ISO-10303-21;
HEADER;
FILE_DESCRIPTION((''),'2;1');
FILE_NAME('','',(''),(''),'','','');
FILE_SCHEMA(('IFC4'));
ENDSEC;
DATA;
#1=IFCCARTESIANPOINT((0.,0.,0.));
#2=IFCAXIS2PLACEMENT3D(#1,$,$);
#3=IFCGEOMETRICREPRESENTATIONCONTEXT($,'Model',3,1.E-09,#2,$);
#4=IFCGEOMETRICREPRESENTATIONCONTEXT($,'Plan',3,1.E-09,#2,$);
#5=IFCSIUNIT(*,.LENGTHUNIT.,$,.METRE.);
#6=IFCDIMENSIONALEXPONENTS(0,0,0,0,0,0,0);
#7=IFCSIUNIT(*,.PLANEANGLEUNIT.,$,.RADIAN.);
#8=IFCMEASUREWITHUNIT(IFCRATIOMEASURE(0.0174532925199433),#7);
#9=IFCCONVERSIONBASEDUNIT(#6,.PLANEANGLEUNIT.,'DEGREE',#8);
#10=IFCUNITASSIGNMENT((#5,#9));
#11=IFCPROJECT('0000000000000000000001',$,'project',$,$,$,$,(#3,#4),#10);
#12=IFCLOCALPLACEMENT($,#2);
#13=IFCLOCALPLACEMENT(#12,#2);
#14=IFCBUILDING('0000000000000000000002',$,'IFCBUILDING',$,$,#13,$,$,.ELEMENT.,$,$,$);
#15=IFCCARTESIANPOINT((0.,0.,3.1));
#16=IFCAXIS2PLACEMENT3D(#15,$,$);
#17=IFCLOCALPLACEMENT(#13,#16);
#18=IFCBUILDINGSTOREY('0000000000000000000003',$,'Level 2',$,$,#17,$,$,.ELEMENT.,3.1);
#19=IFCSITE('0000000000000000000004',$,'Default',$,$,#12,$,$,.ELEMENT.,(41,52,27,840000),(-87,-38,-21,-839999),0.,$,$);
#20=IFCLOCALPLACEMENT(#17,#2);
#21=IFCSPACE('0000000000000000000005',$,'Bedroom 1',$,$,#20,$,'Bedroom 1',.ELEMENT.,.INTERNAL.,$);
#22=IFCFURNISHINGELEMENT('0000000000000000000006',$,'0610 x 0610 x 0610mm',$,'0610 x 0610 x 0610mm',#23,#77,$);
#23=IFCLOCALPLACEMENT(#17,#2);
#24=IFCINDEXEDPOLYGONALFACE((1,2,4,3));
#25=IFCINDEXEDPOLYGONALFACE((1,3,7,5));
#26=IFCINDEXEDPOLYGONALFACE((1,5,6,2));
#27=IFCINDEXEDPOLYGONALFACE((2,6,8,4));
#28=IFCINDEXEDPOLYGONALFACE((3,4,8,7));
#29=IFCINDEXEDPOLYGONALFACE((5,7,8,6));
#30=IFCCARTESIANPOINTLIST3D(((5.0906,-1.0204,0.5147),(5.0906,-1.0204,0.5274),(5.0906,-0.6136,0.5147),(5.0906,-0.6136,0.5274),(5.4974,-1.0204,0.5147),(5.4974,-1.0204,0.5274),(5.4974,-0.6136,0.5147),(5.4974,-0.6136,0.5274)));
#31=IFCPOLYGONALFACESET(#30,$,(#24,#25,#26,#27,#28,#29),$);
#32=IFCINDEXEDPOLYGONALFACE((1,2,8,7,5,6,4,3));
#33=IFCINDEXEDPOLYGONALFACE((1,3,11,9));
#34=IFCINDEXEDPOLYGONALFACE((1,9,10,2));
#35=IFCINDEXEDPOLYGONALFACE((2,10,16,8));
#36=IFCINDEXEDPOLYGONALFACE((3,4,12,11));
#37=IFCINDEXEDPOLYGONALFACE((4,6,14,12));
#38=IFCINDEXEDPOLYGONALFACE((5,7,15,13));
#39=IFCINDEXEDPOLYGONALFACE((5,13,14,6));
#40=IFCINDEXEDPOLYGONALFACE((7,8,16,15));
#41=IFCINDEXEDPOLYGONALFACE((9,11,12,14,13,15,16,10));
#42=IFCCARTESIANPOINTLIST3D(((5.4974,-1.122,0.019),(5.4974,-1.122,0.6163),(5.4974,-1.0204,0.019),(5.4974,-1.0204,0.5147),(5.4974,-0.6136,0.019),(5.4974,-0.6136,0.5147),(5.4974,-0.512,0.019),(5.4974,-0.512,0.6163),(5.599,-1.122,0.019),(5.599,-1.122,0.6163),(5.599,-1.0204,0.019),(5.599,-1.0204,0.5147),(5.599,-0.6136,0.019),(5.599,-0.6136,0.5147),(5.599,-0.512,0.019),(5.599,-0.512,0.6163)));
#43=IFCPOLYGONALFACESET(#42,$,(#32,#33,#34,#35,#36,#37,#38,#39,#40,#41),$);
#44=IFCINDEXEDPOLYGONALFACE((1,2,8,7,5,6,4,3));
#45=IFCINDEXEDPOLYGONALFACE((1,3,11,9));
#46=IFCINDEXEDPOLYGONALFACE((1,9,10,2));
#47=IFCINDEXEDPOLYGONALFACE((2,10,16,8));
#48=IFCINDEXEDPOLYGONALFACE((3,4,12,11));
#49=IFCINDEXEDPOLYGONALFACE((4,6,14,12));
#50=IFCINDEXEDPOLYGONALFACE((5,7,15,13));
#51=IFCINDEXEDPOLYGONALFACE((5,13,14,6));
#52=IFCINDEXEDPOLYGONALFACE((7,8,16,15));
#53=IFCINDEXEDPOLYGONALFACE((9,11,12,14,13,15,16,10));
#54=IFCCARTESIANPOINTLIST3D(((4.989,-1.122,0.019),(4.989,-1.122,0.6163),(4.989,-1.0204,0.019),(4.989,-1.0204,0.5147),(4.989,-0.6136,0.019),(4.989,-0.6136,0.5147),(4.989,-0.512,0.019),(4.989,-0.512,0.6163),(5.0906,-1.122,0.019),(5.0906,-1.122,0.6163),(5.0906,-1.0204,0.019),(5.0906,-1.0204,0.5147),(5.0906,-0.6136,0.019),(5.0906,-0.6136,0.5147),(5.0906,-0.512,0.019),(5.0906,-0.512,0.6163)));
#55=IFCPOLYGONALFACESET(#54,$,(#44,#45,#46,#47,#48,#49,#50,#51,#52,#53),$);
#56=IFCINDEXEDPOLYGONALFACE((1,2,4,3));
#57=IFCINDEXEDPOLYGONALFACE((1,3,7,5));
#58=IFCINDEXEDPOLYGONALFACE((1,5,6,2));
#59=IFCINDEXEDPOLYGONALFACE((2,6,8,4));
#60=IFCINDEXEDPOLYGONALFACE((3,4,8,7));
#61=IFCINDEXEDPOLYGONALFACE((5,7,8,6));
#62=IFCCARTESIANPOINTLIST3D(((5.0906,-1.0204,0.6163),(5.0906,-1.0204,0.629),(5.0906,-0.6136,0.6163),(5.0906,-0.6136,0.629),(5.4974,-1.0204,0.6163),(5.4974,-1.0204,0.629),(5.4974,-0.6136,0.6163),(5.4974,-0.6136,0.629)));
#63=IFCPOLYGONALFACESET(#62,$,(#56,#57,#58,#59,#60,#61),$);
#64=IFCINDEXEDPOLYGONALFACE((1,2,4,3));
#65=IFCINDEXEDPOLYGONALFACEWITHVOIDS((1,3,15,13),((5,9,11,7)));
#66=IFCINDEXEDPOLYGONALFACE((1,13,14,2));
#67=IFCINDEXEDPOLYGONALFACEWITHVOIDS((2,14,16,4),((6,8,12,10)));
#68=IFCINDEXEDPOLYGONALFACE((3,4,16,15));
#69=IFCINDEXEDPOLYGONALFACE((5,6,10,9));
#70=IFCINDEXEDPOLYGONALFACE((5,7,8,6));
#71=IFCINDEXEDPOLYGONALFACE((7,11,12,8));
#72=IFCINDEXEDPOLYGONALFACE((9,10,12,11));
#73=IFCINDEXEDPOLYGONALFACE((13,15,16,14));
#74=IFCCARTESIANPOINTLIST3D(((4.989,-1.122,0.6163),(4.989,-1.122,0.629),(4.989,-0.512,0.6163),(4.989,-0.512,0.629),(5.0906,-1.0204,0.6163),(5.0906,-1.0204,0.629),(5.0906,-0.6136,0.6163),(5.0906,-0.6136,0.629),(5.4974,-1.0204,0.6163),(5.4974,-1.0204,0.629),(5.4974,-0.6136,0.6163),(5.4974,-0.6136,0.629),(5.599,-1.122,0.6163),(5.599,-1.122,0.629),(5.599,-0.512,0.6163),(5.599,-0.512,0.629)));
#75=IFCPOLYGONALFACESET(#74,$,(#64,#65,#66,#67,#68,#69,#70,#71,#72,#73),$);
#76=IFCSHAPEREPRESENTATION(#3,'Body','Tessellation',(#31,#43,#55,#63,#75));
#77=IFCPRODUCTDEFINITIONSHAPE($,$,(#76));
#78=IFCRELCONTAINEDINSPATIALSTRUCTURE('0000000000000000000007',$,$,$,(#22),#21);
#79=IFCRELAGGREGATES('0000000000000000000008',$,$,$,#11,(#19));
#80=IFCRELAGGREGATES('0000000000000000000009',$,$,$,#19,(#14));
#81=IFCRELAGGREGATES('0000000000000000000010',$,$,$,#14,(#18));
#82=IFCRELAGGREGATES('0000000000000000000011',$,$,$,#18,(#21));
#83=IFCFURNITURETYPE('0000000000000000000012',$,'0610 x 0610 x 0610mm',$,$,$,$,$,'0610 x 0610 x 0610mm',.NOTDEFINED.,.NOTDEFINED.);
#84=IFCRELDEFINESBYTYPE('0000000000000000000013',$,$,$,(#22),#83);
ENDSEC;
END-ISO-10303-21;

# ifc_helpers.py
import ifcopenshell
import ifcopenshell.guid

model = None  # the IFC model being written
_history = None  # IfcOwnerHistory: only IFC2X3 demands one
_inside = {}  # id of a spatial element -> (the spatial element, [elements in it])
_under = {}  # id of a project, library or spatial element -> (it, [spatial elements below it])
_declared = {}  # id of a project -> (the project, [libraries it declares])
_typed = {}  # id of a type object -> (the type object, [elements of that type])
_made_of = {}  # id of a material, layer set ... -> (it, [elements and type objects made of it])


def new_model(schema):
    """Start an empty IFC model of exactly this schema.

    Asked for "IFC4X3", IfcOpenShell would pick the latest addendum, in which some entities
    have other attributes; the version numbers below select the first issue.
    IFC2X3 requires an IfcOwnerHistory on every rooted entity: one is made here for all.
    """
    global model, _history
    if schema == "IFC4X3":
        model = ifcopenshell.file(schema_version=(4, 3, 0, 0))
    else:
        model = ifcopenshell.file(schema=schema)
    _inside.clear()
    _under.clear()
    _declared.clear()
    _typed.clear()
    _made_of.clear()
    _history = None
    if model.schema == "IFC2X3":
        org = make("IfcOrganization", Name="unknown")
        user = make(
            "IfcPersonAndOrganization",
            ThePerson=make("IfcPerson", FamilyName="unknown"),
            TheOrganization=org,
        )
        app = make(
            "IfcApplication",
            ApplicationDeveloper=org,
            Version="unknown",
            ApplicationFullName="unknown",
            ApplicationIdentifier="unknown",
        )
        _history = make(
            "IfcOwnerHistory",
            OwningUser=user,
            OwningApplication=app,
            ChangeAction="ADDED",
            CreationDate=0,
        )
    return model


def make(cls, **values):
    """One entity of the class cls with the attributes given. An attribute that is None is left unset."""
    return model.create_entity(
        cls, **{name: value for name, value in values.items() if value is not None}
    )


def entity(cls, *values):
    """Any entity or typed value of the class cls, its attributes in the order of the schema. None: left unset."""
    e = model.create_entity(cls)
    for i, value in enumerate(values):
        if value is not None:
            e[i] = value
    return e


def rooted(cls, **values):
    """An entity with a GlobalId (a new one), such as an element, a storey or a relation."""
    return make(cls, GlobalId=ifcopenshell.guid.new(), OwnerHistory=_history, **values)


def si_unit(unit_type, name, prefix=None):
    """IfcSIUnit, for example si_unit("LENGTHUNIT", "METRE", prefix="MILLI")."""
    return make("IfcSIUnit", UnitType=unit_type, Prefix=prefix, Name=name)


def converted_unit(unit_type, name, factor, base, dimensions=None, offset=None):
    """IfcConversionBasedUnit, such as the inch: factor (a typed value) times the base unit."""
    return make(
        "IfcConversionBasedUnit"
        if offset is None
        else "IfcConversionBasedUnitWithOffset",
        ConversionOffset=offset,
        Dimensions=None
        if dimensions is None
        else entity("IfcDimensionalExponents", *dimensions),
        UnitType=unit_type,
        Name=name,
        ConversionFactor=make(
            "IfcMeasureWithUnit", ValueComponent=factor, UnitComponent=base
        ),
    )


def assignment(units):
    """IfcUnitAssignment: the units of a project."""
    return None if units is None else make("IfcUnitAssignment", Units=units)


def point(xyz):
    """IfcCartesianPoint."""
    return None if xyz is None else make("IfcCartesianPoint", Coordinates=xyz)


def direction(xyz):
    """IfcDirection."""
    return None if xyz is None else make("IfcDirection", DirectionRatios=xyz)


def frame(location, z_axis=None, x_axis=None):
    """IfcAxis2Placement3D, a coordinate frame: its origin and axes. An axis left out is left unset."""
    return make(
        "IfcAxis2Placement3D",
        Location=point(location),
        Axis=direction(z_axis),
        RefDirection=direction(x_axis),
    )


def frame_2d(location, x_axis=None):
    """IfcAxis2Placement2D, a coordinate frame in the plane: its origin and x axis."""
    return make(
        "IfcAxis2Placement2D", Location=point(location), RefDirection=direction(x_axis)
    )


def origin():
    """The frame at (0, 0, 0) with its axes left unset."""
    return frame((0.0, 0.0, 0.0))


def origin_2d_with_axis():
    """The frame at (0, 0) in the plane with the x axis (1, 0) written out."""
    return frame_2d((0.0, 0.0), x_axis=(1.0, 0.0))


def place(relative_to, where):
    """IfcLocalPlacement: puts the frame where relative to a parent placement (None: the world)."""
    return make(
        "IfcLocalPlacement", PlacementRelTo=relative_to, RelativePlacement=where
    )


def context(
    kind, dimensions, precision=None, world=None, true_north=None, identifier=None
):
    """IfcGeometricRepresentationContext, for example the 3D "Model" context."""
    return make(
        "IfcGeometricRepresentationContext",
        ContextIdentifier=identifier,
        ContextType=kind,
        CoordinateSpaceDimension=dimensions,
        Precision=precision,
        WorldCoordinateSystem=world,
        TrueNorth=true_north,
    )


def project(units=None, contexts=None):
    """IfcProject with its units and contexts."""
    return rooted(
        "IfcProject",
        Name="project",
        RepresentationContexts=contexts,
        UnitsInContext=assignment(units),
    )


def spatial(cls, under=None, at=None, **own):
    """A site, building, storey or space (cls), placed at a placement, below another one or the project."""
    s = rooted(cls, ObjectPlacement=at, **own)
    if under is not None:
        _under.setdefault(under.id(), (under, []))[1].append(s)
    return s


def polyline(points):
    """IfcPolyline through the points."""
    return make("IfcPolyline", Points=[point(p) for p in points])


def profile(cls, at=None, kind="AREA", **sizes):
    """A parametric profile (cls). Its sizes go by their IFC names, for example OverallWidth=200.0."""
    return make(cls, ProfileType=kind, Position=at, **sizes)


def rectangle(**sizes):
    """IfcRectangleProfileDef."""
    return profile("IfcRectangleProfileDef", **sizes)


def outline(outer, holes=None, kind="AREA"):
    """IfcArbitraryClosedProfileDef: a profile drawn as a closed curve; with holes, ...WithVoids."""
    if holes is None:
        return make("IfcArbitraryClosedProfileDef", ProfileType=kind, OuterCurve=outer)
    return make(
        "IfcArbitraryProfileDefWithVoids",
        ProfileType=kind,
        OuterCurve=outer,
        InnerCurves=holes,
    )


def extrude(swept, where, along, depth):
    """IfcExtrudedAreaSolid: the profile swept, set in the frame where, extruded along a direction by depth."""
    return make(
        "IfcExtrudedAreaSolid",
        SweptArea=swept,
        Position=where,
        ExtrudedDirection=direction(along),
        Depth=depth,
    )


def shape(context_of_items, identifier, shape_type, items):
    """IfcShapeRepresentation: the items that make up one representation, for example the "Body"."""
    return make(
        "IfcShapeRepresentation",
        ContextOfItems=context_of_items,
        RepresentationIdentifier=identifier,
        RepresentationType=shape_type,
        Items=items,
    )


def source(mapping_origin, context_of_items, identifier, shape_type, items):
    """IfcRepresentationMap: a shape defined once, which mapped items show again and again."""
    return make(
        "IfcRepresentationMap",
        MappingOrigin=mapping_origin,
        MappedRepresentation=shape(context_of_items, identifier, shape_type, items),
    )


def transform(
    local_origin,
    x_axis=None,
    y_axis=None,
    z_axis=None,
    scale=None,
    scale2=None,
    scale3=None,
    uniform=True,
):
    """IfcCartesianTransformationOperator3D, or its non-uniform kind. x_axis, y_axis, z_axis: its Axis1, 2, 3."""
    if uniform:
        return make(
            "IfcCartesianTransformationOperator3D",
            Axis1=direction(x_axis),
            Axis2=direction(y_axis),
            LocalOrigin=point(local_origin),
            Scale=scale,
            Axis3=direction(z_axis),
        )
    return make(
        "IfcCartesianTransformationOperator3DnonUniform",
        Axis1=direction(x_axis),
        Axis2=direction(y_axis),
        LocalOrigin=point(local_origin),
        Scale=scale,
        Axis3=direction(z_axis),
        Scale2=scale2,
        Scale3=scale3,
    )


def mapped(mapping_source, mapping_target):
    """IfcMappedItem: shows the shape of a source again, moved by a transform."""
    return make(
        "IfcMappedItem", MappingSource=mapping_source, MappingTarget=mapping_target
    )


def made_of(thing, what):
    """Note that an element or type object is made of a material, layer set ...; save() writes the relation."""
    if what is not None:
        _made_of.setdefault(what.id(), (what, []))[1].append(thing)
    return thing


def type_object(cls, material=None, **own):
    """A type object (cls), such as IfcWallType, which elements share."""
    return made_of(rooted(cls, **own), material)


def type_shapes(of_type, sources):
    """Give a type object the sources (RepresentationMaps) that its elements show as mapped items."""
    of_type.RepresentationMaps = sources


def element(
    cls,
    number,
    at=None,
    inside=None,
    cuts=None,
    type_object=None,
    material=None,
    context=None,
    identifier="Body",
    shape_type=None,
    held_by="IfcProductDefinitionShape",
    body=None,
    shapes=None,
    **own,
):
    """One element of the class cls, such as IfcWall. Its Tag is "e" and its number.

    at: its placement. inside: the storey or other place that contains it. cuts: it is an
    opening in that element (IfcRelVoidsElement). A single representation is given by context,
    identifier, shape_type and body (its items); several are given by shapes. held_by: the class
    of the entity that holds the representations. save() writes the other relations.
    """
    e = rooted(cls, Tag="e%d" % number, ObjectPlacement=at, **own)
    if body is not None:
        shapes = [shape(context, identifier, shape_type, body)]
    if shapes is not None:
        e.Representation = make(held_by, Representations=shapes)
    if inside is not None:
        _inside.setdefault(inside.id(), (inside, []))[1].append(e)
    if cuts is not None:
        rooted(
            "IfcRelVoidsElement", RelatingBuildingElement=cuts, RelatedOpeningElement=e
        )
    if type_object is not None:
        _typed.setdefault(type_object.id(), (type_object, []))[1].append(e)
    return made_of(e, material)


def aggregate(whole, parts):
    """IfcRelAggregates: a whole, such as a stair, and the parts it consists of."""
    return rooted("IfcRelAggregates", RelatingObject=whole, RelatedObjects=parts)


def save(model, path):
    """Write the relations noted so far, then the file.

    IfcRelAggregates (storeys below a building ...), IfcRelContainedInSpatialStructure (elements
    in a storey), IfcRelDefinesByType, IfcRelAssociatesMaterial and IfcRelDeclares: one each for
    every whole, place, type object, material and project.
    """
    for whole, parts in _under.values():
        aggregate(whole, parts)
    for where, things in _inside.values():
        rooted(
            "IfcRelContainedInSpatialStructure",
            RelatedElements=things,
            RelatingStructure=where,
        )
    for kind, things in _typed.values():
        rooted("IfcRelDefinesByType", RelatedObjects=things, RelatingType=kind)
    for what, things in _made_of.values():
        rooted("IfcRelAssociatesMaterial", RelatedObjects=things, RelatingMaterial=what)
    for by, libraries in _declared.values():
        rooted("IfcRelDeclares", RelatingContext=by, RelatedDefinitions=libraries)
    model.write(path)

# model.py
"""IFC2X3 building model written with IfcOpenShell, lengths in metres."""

from ifc_helpers import new_model, entity, si_unit, converted_unit, frame, origin, origin_2d_with_axis, place, context, project, spatial, polyline, rectangle, outline, extrude, source, transform, mapped, type_object, type_shapes, element, save


model = new_model("IFC2X3")

# Units and contexts
model_context = context("Model", 3, precision=1e-09, world=origin())
plan_context = context("Plan", 3, precision=1e-09, world=origin())
ifc_project = project(units=[si_unit("LENGTHUNIT", "METRE"), converted_unit("PLANEANGLEUNIT", "DEGREE", entity("IfcRatioMeasure", 0.0174532925199433), si_unit("PLANEANGLEUNIT", "RADIAN"), dimensions=[0, 0, 0, 0, 0, 0, 0])], contexts=[model_context, plan_context])

# Site, building, storey
site_placement = place(None, origin())
site = spatial("IfcSite", under=ifc_project, at=site_placement, Name="Default", CompositionType="ELEMENT", RefLatitude=(41, 52, 27, 840000), RefLongitude=(-87, -38, -21, -839999), RefElevation=0.0)
building_placement = place(site_placement, origin())
building = spatial("IfcBuilding", under=site, at=building_placement, Name="IFCBUILDING", CompositionType="ELEMENT")
storey_placement = place(building_placement, frame((0.0, 0.0, 3.1)))
storey = spatial("IfcBuildingStorey", under=building, at=storey_placement, Name="Level 2", CompositionType="ELEMENT", Elevation=3.1)

# Shared definitions
furniture_type = type_object("IfcFurnitureType", Name="0610 x 0610 x 0610mm", ElementType="0610 x 0610 x 0610mm", AssemblyPlace="NOTDEFINED")
shared_shape_1 = source(origin(), model_context, "Body", "SweptSolid", [
    extrude(rectangle(XDim=0.4068, YDim=0.4068, at=origin_2d_with_axis()), frame((0.0183, 0.0952, 0.4957), z_axis=(0.0, 0.0, 1.0), x_axis=(-1.0, 0.0, 0.0)), (0.0, 0.0, 1.0), 0.0127),
    extrude(outline(polyline([(-0.2732, -0.305), (0.324, -0.305), (0.324, 0.305), (-0.2732, 0.305), (-0.2732, 0.2034), (0.2225, 0.2034), (0.2225, -0.2034), (-0.2732, -0.2034), (-0.2732, -0.305)])), frame((0.2217, 0.0952, 0.2732), z_axis=(1.0, 0.0, 0.0), x_axis=(0.0, 0.0, 1.0)), (0.0, 0.0, 1.0), 0.1016),
    extrude(outline(polyline([(-0.305, -0.3241), (0.305, -0.3241), (0.305, 0.2733), (0.2034, 0.2733), (0.2034, -0.2224), (-0.2034, -0.2224), (-0.2034, 0.2733), (-0.305, 0.2733), (-0.305, -0.3241)])), frame((-0.2867, 0.0952, 0.2733), z_axis=(1.0, 0.0, 0.0), x_axis=(0.0, -1.0, 0.0)), (0.0, 0.0, 1.0), 0.1016),
    extrude(rectangle(XDim=0.4068, YDim=0.4068, at=origin_2d_with_axis()), frame((0.0183, 0.0952, 0.5973), z_axis=(0.0, 0.0, 1.0), x_axis=(-1.0, 0.0, 0.0)), (0.0, 0.0, 1.0), 0.0127),
    extrude(outline(polyline([(-0.305, -0.305), (0.305, -0.305), (0.305, 0.305), (-0.305, 0.305), (-0.305, -0.305)]), holes=[polyline([(-0.2034, -0.2034), (-0.2034, 0.2034), (0.2034, 0.2034), (0.2034, -0.2034), (-0.2034, -0.2034)])]), frame((0.0183, 0.0952, 0.5973), z_axis=(0.0, 0.0, 1.0), x_axis=(-1.0, 0.0, 0.0)), (0.0, 0.0, 1.0), 0.0127),
])
type_shapes(furniture_type, [shared_shape_1])

# Shared definitions
space_1_placement = place(storey_placement, origin())
space_1 = spatial("IfcSpace", under=storey, at=space_1_placement, Name="Bedroom 1", LongName="Bedroom 1", CompositionType="ELEMENT", InteriorOrExteriorSpace="INTERNAL")

# Furnishing element
furnishing_1_placement = place(space_1_placement, frame((5.2757, -0.9122, 0.019)))
element("IfcFurnishingElement", 1, at=furnishing_1_placement, inside=space_1, type_object=furniture_type, Name="0610 x 0610 x 0610mm", ObjectType="0610 x 0610 x 0610mm", context=model_context, shape_type="MappedRepresentation", body=[
    mapped(shared_shape_1, transform((0.0, 0.0, 0.0), scale=1.0)),
])

save(model, "model.ifc")
